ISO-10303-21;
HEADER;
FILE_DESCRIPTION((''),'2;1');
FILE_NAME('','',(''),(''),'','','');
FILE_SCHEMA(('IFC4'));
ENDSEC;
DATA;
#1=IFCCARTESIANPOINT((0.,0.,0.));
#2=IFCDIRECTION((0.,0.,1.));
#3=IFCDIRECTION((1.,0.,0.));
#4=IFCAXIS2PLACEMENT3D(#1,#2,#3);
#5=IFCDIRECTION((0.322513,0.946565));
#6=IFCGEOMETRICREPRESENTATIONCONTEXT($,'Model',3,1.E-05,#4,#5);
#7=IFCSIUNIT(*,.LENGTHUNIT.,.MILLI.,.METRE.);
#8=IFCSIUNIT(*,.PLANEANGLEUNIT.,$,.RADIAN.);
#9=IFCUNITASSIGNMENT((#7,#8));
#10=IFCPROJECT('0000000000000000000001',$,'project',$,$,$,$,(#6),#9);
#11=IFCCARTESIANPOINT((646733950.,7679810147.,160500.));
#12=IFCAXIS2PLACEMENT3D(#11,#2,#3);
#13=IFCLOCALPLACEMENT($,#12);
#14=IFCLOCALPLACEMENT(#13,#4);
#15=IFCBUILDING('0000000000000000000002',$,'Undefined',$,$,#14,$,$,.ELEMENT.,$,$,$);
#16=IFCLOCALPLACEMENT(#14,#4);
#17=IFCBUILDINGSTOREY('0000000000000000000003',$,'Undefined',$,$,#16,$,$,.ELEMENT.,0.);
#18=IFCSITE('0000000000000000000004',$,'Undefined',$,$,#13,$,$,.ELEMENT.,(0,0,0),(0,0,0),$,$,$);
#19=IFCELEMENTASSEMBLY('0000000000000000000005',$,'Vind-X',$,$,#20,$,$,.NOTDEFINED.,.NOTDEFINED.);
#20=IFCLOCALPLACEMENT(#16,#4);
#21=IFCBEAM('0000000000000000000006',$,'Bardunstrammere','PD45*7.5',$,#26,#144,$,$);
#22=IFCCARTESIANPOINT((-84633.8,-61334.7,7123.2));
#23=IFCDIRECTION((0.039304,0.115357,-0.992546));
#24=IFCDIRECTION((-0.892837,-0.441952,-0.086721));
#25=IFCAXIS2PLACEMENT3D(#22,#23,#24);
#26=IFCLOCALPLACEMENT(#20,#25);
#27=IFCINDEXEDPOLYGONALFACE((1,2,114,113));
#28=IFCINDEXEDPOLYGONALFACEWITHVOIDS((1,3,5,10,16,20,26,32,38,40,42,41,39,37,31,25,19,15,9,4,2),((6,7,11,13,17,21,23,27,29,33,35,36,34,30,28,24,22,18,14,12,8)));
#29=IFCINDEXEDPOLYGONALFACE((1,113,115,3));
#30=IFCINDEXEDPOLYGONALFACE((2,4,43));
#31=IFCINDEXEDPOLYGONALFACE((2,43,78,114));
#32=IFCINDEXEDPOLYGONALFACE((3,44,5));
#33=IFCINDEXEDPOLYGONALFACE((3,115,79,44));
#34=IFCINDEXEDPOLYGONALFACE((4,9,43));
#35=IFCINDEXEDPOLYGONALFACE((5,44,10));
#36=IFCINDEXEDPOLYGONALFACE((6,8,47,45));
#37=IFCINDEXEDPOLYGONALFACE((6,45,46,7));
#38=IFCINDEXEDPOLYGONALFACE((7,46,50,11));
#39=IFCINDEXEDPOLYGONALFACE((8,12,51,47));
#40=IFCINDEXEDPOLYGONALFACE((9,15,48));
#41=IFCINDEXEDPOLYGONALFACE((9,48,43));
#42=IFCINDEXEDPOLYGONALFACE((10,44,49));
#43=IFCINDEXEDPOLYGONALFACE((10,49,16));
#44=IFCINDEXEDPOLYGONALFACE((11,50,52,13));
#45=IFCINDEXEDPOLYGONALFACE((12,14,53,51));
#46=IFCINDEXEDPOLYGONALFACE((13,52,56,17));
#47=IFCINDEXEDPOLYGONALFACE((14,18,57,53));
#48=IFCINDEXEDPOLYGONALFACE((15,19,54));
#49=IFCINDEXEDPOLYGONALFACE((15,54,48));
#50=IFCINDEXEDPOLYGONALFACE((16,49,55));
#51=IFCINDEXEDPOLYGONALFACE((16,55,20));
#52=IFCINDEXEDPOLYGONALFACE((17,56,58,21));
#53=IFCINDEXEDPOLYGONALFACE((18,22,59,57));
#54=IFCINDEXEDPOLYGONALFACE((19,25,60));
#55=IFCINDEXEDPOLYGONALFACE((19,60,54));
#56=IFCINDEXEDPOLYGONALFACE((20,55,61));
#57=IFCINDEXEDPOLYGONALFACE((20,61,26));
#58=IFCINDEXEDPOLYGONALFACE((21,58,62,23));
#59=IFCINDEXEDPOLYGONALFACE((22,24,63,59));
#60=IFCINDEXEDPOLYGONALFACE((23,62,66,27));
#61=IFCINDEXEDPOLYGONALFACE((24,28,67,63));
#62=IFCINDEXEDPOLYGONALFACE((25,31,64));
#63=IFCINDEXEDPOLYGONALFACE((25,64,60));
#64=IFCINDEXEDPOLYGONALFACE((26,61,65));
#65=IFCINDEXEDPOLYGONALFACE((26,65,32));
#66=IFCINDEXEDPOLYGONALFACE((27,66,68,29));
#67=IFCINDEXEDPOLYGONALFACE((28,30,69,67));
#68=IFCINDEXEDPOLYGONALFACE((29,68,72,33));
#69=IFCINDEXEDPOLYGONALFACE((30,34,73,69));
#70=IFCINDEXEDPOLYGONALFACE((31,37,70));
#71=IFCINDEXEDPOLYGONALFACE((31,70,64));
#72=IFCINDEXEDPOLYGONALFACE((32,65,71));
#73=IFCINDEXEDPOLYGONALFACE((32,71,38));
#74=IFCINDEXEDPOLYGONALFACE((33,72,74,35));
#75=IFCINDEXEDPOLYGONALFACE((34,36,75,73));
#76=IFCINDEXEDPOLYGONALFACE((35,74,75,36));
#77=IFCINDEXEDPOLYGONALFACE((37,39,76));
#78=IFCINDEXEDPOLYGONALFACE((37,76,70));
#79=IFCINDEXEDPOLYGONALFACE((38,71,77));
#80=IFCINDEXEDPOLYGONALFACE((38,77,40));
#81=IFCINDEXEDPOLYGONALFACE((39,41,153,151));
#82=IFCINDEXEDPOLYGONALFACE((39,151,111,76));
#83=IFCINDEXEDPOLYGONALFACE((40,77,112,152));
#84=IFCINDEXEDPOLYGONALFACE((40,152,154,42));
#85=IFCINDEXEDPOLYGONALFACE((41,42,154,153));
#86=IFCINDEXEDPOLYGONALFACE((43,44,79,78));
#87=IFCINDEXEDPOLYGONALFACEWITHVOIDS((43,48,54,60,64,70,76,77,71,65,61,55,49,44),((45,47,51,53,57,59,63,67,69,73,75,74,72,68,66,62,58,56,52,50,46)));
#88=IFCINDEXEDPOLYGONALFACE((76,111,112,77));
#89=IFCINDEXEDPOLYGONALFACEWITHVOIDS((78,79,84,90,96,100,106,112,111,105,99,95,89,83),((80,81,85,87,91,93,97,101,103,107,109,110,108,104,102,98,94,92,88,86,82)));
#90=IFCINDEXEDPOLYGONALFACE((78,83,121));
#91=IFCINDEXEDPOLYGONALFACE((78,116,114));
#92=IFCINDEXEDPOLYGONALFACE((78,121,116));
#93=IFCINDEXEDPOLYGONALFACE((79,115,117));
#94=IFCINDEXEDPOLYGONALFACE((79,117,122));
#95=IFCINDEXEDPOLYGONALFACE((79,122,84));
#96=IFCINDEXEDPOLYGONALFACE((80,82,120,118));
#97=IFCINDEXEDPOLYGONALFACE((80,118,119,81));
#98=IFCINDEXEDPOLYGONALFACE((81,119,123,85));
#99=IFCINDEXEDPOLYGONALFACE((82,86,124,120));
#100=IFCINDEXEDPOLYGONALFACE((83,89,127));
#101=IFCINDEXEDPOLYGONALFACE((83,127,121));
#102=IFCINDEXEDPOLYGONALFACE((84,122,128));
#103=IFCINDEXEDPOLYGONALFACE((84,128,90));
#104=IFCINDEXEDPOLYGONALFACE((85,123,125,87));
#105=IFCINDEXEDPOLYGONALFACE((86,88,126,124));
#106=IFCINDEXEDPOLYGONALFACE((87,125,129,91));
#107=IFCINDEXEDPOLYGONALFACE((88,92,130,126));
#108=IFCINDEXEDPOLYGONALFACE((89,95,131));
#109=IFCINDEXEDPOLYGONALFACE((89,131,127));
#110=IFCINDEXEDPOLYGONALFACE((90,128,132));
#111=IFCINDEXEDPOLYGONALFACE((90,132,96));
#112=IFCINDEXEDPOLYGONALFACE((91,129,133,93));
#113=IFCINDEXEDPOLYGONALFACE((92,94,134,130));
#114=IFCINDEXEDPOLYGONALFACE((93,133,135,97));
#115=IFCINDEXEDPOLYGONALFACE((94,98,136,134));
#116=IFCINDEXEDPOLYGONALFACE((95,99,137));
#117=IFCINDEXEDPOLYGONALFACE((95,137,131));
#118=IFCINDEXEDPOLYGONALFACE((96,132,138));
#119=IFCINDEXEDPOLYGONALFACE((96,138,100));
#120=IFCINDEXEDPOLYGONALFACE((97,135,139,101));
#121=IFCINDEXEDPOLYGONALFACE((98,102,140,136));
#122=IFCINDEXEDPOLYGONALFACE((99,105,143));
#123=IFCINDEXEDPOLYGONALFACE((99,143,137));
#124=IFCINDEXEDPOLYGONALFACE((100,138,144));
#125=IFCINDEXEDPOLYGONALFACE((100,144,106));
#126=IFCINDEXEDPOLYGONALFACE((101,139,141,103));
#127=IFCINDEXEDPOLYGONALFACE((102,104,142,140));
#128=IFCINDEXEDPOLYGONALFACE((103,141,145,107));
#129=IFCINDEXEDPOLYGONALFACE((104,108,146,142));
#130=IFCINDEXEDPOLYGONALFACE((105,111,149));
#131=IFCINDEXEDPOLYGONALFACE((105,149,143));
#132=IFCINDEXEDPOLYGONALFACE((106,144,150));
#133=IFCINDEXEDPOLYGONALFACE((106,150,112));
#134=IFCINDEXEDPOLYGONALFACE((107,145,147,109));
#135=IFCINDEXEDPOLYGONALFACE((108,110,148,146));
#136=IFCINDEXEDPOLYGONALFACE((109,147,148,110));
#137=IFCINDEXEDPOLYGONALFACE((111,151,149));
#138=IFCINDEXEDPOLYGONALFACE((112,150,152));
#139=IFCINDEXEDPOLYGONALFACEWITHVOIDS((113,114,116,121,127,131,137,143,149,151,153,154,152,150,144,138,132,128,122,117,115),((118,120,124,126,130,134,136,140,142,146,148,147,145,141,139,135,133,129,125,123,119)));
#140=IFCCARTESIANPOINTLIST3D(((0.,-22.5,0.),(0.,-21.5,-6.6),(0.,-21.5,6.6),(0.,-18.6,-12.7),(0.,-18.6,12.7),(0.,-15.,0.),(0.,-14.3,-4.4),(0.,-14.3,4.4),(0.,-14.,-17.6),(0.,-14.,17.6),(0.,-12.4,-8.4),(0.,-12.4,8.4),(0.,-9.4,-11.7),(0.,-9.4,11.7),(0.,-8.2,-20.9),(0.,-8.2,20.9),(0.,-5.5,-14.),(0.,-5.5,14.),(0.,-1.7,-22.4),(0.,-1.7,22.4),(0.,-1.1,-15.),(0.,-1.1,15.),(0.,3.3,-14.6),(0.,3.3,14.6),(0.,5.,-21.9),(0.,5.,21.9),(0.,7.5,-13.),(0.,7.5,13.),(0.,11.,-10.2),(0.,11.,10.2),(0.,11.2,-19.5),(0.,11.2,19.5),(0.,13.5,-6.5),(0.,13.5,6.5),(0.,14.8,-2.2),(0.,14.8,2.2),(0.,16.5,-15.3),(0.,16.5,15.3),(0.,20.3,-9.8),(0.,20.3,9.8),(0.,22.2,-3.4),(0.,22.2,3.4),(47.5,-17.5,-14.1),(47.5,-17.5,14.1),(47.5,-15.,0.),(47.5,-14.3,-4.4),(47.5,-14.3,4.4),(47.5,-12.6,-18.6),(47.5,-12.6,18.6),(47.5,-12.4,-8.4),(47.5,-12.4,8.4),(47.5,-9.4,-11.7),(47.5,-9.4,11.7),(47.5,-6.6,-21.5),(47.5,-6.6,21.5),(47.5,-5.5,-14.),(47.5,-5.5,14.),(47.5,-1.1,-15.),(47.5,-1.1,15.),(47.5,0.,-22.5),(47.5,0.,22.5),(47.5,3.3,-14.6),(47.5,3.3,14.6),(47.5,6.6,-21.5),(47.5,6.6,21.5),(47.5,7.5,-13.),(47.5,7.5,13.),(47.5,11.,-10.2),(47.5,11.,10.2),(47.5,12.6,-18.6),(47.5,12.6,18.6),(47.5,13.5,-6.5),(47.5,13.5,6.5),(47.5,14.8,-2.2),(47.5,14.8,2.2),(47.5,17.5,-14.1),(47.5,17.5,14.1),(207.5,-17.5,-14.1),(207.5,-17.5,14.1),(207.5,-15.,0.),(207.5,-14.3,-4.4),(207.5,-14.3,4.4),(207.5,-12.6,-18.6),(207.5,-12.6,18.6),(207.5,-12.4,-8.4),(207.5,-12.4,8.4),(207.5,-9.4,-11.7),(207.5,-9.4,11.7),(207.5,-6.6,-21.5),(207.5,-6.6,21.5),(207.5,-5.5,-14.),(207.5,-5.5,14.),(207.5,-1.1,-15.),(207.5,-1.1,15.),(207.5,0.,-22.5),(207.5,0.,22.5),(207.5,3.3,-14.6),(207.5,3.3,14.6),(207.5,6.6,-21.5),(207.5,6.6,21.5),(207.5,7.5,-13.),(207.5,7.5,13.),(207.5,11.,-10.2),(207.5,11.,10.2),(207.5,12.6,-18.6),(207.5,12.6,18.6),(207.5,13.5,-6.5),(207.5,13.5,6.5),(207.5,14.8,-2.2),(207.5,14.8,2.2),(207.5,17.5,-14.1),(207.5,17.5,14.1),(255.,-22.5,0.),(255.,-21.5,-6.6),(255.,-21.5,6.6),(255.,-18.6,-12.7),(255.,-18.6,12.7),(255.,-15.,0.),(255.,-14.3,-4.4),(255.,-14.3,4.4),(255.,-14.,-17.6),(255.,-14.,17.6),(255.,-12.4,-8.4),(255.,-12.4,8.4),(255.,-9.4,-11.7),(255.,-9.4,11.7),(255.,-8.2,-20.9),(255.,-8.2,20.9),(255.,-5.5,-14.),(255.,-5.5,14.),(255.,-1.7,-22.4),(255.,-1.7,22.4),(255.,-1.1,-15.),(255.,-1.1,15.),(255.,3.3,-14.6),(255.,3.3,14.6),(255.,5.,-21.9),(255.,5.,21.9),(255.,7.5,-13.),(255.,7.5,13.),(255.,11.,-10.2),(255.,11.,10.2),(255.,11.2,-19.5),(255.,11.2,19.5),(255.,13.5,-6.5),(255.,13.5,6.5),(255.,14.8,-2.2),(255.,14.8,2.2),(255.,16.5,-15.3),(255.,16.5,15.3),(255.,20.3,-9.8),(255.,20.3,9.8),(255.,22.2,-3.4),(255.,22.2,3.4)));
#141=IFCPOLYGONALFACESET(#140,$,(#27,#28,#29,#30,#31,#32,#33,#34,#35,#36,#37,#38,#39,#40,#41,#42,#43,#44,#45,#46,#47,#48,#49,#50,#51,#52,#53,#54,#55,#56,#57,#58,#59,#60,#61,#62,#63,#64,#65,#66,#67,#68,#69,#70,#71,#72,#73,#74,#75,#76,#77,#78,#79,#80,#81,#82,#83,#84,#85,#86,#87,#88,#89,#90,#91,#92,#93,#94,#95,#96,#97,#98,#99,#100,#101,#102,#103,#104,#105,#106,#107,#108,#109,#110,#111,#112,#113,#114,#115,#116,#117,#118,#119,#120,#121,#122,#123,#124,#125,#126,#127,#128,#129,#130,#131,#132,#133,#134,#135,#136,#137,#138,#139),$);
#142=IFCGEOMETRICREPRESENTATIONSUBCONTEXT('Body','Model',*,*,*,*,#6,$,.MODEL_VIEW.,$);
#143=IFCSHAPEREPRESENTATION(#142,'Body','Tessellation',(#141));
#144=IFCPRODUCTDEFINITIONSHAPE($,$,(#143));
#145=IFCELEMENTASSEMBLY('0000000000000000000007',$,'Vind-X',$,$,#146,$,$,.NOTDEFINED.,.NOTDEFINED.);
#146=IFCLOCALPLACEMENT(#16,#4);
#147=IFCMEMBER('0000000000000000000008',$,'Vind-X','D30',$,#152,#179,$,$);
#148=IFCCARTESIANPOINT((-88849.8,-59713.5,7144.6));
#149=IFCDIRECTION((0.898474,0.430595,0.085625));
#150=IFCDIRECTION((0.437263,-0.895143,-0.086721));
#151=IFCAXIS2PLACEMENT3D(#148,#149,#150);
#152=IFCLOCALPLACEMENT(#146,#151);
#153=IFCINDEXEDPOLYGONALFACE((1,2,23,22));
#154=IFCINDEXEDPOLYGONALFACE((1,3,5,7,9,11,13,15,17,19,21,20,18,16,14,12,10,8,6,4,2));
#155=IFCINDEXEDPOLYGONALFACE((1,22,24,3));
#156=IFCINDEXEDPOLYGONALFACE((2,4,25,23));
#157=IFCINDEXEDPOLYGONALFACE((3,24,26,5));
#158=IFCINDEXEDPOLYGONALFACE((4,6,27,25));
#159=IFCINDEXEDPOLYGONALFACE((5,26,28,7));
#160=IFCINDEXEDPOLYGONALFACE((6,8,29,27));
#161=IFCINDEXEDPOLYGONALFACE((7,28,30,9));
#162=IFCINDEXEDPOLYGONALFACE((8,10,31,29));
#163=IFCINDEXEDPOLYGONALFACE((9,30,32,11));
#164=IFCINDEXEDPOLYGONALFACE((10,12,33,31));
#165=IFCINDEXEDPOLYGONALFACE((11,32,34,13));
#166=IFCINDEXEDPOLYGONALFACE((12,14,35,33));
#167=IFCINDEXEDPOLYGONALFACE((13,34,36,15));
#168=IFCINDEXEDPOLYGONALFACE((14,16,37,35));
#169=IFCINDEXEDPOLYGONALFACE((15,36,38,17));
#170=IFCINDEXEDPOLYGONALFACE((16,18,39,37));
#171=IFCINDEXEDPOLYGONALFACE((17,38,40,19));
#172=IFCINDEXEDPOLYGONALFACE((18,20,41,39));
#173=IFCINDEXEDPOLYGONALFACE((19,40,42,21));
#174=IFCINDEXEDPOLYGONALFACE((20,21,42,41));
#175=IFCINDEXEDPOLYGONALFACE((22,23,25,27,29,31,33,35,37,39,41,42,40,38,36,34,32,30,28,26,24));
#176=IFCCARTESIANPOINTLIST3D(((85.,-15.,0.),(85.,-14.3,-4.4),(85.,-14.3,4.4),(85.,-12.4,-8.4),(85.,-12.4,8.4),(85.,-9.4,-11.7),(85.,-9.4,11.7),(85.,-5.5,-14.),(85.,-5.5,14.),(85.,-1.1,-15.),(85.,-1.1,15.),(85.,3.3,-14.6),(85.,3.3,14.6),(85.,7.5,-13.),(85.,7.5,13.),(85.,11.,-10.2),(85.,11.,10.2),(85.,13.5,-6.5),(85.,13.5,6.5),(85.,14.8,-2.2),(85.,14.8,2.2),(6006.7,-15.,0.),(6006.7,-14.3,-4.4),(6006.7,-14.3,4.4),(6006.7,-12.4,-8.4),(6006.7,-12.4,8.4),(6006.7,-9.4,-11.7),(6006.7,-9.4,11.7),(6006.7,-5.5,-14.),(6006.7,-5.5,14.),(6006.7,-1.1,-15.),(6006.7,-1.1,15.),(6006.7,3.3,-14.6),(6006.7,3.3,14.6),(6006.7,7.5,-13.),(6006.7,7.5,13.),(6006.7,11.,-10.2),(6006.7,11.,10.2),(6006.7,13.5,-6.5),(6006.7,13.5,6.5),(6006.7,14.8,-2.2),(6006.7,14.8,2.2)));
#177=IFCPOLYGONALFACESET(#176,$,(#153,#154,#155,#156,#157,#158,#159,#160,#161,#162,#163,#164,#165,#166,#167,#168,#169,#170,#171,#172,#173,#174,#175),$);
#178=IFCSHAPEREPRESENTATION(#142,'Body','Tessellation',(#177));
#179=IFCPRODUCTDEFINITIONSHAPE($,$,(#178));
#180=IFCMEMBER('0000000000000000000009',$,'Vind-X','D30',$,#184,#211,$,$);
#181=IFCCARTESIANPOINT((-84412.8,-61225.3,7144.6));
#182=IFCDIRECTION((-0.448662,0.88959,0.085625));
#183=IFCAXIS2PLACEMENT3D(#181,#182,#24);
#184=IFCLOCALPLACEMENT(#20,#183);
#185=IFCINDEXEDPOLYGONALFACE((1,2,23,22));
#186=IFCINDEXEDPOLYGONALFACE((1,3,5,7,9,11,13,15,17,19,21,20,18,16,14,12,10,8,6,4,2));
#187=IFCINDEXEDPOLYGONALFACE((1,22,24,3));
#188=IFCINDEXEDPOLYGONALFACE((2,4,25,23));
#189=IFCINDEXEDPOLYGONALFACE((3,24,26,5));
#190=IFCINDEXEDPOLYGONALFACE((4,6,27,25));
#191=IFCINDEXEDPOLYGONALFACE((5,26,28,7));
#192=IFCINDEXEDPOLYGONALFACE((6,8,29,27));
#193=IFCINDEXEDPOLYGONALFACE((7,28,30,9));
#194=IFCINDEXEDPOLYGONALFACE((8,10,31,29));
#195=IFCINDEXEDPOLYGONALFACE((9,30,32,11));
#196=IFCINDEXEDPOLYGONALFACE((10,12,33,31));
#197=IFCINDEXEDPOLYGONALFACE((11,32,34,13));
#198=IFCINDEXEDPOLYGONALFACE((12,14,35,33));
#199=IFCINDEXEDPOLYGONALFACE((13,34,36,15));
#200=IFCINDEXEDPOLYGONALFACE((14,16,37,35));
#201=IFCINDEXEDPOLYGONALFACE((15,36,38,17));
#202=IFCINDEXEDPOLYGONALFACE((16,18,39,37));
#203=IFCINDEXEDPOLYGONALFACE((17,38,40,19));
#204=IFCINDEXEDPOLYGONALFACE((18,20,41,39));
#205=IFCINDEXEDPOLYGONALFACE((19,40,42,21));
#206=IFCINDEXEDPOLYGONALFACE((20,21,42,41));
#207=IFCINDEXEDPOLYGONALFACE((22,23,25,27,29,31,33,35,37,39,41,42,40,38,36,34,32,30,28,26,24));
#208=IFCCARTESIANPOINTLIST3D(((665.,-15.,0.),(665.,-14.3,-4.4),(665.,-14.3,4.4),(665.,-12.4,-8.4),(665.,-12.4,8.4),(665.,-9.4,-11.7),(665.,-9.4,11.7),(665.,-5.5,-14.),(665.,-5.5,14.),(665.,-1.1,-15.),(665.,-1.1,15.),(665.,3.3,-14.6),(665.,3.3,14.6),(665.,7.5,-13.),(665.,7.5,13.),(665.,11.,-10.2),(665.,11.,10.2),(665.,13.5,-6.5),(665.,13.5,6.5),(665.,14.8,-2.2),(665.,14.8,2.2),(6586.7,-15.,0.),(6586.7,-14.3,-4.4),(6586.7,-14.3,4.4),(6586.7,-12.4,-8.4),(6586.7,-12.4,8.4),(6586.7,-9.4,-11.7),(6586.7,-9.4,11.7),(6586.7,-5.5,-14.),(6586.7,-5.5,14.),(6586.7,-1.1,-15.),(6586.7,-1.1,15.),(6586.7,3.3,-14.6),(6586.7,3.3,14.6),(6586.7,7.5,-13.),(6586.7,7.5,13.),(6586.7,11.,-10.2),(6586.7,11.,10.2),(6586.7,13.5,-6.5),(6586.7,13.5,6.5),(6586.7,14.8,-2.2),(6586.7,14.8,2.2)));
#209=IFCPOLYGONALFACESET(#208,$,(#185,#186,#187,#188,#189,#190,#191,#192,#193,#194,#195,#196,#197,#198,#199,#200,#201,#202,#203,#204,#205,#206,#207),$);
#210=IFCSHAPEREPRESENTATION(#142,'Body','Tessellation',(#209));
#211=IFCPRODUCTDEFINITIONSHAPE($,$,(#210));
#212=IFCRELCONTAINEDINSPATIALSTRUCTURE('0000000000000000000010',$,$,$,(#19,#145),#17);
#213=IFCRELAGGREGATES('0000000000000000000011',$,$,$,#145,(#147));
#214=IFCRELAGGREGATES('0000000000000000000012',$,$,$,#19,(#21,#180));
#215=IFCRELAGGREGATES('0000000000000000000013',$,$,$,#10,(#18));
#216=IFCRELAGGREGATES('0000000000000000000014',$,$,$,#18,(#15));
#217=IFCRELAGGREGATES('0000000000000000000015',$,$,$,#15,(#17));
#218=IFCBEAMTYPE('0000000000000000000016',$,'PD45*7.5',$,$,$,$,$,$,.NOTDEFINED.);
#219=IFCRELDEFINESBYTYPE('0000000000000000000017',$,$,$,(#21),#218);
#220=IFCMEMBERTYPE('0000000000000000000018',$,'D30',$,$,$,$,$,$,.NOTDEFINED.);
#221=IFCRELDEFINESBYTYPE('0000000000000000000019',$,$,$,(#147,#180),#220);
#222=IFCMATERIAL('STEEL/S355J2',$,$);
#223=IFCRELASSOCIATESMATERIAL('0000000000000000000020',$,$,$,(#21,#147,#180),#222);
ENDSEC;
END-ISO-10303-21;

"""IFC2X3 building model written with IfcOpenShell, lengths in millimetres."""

from ifc_helpers import new_model, si_unit, direction, frame, origin_with_axes, origin_2d_with_axis, place, context, subcontext, project, spatial, rectangle, circle, hollow_circle, extrude, boolean, clip, halfspace, material, type_object, element, aggregate, save


model = new_model("IFC2X3")

# Units and contexts
model_context = context("Model", 3, precision=1e-05, world=origin_with_axes(), true_north=direction((0.322513, 0.946565)))
body_context = subcontext(model_context, "Body", "Model", "MODEL_VIEW")
ifc_project = project(units=[si_unit("LENGTHUNIT", "METRE", prefix="MILLI"), si_unit("PLANEANGLEUNIT", "RADIAN")], contexts=[model_context])

# Site, building, storey
site_placement = place(None, frame((646733950.0, 7679810147.0, 160500.0), z_axis=(0.0, 0.0, 1.0), x_axis=(1.0, 0.0, 0.0)))
site = spatial("IfcSite", under=ifc_project, at=site_placement, Name="Undefined", CompositionType="ELEMENT", RefLatitude=(0, 0, 0), RefLongitude=(0, 0, 0))
building_placement = place(site_placement, origin_with_axes())
building = spatial("IfcBuilding", under=site, at=building_placement, Name="Undefined", CompositionType="ELEMENT")
storey_placement = place(building_placement, origin_with_axes())
storey = spatial("IfcBuildingStorey", under=building, at=storey_placement, Name="Undefined", CompositionType="ELEMENT", Elevation=0.0)

# Element assembly, beam
ifc_material_1 = material(Name="STEEL/S355J2")
beam_type_1 = type_object("IfcBeamType", Name="PD45*7.5", PredefinedType="NOTDEFINED")
assembly_1_placement = place(storey_placement, origin_with_axes())
assembly_1 = element("IfcElementAssembly", 1, at=assembly_1_placement, inside=storey, Name="Vind-X", AssemblyPlace="NOTDEFINED", PredefinedType="NOTDEFINED")
beam_1_placement = place(assembly_1_placement, frame((-84633.8, -61334.7, 7123.2), z_axis=(0.039304, 0.115357, -0.992546), x_axis=(-0.892837, -0.441952, -0.086721)))
beam_1 = element("IfcBeam", 2, at=beam_1_placement, type_object=beam_type_1, material=ifc_material_1, Name="Bardunstrammere", Description="PD45*7.5", context=body_context, shape_type="CSG", body=[
    boolean("DIFFERENCE", extrude(hollow_circle(Radius=22.5, WallThickness=7.5, at=origin_2d_with_axis()), frame((255.0, 0.0, 0.0), z_axis=(-1.0, 0.0, 0.0), x_axis=(0.0, -1.0, 0.0)), (0.0, 0.0, 1.0), 255.0), extrude(rectangle(XDim=35.0, YDim=90.0, at=origin_2d_with_axis()), frame((207.5, 0.0, 0.0), z_axis=(-1.0, 0.0, 0.0), x_axis=(0.0, -1.0, 0.0)), (0.0, 0.0, 1.0), 160.0)),
])

# Element assembly, member
assembly_2_placement = place(storey_placement, origin_with_axes())
assembly_2 = element("IfcElementAssembly", 3, at=assembly_2_placement, inside=storey, Name="Vind-X", AssemblyPlace="NOTDEFINED", PredefinedType="NOTDEFINED")
member_type_1 = type_object("IfcMemberType", Name="D30", PredefinedType="NOTDEFINED")
member_1_placement = place(assembly_2_placement, frame((-88849.8, -59713.5, 7144.6), z_axis=(0.898474, 0.430595, 0.085625), x_axis=(0.437263, -0.895143, -0.086721)))
member_1 = element("IfcMember", 4, at=member_1_placement, type_object=member_type_1, material=ifc_material_1, Name="Vind-X", Description="D30", context=body_context, shape_type="Clipping", body=[
    clip(clip(extrude(circle(Radius=15.0, at=origin_2d_with_axis()), frame((6671.7, 0.0, 0.0), z_axis=(-1.0, 0.0, 0.0), x_axis=(0.0, -1.0, 0.0)), (0.0, 0.0, 1.0), 6671.7), halfspace(frame((6006.7, -6.0, 10.2), z_axis=(1.0, 0.0, 0.0), x_axis=(0.0, 1.0, 0.0)), False)), halfspace(frame((85.0, -6.0, 16.0), z_axis=(1.0, 0.0, 0.0), x_axis=(0.0, 1.0, 0.0)), True)),
])
aggregate(assembly_2, [member_1])

# Member
member_2_placement = place(assembly_1_placement, frame((-84412.8, -61225.3, 7144.6), z_axis=(-0.448662, 0.88959, 0.085625), x_axis=(-0.892837, -0.441952, -0.086721)))
member_2 = element("IfcMember", 5, at=member_2_placement, type_object=member_type_1, material=ifc_material_1, Name="Vind-X", Description="D30", context=body_context, shape_type="Clipping", body=[
    clip(clip(extrude(circle(Radius=15.0, at=origin_2d_with_axis()), frame((6671.7, 0.0, 0.0), z_axis=(-1.0, 0.0, 0.0), x_axis=(0.0, -1.0, 0.0)), (0.0, 0.0, 1.0), 6671.7), halfspace(frame((6586.7, 6.0, 16.0), z_axis=(-1.0, 0.0, 0.0), x_axis=(0.0, -1.0, 0.0)), True)), halfspace(frame((665.0, 6.0, 10.2), z_axis=(-1.0, 0.0, 0.0), x_axis=(0.0, -1.0, 0.0)), False)),
])

aggregate(assembly_1, [beam_1, member_2])

save(model, "model.ifc")
